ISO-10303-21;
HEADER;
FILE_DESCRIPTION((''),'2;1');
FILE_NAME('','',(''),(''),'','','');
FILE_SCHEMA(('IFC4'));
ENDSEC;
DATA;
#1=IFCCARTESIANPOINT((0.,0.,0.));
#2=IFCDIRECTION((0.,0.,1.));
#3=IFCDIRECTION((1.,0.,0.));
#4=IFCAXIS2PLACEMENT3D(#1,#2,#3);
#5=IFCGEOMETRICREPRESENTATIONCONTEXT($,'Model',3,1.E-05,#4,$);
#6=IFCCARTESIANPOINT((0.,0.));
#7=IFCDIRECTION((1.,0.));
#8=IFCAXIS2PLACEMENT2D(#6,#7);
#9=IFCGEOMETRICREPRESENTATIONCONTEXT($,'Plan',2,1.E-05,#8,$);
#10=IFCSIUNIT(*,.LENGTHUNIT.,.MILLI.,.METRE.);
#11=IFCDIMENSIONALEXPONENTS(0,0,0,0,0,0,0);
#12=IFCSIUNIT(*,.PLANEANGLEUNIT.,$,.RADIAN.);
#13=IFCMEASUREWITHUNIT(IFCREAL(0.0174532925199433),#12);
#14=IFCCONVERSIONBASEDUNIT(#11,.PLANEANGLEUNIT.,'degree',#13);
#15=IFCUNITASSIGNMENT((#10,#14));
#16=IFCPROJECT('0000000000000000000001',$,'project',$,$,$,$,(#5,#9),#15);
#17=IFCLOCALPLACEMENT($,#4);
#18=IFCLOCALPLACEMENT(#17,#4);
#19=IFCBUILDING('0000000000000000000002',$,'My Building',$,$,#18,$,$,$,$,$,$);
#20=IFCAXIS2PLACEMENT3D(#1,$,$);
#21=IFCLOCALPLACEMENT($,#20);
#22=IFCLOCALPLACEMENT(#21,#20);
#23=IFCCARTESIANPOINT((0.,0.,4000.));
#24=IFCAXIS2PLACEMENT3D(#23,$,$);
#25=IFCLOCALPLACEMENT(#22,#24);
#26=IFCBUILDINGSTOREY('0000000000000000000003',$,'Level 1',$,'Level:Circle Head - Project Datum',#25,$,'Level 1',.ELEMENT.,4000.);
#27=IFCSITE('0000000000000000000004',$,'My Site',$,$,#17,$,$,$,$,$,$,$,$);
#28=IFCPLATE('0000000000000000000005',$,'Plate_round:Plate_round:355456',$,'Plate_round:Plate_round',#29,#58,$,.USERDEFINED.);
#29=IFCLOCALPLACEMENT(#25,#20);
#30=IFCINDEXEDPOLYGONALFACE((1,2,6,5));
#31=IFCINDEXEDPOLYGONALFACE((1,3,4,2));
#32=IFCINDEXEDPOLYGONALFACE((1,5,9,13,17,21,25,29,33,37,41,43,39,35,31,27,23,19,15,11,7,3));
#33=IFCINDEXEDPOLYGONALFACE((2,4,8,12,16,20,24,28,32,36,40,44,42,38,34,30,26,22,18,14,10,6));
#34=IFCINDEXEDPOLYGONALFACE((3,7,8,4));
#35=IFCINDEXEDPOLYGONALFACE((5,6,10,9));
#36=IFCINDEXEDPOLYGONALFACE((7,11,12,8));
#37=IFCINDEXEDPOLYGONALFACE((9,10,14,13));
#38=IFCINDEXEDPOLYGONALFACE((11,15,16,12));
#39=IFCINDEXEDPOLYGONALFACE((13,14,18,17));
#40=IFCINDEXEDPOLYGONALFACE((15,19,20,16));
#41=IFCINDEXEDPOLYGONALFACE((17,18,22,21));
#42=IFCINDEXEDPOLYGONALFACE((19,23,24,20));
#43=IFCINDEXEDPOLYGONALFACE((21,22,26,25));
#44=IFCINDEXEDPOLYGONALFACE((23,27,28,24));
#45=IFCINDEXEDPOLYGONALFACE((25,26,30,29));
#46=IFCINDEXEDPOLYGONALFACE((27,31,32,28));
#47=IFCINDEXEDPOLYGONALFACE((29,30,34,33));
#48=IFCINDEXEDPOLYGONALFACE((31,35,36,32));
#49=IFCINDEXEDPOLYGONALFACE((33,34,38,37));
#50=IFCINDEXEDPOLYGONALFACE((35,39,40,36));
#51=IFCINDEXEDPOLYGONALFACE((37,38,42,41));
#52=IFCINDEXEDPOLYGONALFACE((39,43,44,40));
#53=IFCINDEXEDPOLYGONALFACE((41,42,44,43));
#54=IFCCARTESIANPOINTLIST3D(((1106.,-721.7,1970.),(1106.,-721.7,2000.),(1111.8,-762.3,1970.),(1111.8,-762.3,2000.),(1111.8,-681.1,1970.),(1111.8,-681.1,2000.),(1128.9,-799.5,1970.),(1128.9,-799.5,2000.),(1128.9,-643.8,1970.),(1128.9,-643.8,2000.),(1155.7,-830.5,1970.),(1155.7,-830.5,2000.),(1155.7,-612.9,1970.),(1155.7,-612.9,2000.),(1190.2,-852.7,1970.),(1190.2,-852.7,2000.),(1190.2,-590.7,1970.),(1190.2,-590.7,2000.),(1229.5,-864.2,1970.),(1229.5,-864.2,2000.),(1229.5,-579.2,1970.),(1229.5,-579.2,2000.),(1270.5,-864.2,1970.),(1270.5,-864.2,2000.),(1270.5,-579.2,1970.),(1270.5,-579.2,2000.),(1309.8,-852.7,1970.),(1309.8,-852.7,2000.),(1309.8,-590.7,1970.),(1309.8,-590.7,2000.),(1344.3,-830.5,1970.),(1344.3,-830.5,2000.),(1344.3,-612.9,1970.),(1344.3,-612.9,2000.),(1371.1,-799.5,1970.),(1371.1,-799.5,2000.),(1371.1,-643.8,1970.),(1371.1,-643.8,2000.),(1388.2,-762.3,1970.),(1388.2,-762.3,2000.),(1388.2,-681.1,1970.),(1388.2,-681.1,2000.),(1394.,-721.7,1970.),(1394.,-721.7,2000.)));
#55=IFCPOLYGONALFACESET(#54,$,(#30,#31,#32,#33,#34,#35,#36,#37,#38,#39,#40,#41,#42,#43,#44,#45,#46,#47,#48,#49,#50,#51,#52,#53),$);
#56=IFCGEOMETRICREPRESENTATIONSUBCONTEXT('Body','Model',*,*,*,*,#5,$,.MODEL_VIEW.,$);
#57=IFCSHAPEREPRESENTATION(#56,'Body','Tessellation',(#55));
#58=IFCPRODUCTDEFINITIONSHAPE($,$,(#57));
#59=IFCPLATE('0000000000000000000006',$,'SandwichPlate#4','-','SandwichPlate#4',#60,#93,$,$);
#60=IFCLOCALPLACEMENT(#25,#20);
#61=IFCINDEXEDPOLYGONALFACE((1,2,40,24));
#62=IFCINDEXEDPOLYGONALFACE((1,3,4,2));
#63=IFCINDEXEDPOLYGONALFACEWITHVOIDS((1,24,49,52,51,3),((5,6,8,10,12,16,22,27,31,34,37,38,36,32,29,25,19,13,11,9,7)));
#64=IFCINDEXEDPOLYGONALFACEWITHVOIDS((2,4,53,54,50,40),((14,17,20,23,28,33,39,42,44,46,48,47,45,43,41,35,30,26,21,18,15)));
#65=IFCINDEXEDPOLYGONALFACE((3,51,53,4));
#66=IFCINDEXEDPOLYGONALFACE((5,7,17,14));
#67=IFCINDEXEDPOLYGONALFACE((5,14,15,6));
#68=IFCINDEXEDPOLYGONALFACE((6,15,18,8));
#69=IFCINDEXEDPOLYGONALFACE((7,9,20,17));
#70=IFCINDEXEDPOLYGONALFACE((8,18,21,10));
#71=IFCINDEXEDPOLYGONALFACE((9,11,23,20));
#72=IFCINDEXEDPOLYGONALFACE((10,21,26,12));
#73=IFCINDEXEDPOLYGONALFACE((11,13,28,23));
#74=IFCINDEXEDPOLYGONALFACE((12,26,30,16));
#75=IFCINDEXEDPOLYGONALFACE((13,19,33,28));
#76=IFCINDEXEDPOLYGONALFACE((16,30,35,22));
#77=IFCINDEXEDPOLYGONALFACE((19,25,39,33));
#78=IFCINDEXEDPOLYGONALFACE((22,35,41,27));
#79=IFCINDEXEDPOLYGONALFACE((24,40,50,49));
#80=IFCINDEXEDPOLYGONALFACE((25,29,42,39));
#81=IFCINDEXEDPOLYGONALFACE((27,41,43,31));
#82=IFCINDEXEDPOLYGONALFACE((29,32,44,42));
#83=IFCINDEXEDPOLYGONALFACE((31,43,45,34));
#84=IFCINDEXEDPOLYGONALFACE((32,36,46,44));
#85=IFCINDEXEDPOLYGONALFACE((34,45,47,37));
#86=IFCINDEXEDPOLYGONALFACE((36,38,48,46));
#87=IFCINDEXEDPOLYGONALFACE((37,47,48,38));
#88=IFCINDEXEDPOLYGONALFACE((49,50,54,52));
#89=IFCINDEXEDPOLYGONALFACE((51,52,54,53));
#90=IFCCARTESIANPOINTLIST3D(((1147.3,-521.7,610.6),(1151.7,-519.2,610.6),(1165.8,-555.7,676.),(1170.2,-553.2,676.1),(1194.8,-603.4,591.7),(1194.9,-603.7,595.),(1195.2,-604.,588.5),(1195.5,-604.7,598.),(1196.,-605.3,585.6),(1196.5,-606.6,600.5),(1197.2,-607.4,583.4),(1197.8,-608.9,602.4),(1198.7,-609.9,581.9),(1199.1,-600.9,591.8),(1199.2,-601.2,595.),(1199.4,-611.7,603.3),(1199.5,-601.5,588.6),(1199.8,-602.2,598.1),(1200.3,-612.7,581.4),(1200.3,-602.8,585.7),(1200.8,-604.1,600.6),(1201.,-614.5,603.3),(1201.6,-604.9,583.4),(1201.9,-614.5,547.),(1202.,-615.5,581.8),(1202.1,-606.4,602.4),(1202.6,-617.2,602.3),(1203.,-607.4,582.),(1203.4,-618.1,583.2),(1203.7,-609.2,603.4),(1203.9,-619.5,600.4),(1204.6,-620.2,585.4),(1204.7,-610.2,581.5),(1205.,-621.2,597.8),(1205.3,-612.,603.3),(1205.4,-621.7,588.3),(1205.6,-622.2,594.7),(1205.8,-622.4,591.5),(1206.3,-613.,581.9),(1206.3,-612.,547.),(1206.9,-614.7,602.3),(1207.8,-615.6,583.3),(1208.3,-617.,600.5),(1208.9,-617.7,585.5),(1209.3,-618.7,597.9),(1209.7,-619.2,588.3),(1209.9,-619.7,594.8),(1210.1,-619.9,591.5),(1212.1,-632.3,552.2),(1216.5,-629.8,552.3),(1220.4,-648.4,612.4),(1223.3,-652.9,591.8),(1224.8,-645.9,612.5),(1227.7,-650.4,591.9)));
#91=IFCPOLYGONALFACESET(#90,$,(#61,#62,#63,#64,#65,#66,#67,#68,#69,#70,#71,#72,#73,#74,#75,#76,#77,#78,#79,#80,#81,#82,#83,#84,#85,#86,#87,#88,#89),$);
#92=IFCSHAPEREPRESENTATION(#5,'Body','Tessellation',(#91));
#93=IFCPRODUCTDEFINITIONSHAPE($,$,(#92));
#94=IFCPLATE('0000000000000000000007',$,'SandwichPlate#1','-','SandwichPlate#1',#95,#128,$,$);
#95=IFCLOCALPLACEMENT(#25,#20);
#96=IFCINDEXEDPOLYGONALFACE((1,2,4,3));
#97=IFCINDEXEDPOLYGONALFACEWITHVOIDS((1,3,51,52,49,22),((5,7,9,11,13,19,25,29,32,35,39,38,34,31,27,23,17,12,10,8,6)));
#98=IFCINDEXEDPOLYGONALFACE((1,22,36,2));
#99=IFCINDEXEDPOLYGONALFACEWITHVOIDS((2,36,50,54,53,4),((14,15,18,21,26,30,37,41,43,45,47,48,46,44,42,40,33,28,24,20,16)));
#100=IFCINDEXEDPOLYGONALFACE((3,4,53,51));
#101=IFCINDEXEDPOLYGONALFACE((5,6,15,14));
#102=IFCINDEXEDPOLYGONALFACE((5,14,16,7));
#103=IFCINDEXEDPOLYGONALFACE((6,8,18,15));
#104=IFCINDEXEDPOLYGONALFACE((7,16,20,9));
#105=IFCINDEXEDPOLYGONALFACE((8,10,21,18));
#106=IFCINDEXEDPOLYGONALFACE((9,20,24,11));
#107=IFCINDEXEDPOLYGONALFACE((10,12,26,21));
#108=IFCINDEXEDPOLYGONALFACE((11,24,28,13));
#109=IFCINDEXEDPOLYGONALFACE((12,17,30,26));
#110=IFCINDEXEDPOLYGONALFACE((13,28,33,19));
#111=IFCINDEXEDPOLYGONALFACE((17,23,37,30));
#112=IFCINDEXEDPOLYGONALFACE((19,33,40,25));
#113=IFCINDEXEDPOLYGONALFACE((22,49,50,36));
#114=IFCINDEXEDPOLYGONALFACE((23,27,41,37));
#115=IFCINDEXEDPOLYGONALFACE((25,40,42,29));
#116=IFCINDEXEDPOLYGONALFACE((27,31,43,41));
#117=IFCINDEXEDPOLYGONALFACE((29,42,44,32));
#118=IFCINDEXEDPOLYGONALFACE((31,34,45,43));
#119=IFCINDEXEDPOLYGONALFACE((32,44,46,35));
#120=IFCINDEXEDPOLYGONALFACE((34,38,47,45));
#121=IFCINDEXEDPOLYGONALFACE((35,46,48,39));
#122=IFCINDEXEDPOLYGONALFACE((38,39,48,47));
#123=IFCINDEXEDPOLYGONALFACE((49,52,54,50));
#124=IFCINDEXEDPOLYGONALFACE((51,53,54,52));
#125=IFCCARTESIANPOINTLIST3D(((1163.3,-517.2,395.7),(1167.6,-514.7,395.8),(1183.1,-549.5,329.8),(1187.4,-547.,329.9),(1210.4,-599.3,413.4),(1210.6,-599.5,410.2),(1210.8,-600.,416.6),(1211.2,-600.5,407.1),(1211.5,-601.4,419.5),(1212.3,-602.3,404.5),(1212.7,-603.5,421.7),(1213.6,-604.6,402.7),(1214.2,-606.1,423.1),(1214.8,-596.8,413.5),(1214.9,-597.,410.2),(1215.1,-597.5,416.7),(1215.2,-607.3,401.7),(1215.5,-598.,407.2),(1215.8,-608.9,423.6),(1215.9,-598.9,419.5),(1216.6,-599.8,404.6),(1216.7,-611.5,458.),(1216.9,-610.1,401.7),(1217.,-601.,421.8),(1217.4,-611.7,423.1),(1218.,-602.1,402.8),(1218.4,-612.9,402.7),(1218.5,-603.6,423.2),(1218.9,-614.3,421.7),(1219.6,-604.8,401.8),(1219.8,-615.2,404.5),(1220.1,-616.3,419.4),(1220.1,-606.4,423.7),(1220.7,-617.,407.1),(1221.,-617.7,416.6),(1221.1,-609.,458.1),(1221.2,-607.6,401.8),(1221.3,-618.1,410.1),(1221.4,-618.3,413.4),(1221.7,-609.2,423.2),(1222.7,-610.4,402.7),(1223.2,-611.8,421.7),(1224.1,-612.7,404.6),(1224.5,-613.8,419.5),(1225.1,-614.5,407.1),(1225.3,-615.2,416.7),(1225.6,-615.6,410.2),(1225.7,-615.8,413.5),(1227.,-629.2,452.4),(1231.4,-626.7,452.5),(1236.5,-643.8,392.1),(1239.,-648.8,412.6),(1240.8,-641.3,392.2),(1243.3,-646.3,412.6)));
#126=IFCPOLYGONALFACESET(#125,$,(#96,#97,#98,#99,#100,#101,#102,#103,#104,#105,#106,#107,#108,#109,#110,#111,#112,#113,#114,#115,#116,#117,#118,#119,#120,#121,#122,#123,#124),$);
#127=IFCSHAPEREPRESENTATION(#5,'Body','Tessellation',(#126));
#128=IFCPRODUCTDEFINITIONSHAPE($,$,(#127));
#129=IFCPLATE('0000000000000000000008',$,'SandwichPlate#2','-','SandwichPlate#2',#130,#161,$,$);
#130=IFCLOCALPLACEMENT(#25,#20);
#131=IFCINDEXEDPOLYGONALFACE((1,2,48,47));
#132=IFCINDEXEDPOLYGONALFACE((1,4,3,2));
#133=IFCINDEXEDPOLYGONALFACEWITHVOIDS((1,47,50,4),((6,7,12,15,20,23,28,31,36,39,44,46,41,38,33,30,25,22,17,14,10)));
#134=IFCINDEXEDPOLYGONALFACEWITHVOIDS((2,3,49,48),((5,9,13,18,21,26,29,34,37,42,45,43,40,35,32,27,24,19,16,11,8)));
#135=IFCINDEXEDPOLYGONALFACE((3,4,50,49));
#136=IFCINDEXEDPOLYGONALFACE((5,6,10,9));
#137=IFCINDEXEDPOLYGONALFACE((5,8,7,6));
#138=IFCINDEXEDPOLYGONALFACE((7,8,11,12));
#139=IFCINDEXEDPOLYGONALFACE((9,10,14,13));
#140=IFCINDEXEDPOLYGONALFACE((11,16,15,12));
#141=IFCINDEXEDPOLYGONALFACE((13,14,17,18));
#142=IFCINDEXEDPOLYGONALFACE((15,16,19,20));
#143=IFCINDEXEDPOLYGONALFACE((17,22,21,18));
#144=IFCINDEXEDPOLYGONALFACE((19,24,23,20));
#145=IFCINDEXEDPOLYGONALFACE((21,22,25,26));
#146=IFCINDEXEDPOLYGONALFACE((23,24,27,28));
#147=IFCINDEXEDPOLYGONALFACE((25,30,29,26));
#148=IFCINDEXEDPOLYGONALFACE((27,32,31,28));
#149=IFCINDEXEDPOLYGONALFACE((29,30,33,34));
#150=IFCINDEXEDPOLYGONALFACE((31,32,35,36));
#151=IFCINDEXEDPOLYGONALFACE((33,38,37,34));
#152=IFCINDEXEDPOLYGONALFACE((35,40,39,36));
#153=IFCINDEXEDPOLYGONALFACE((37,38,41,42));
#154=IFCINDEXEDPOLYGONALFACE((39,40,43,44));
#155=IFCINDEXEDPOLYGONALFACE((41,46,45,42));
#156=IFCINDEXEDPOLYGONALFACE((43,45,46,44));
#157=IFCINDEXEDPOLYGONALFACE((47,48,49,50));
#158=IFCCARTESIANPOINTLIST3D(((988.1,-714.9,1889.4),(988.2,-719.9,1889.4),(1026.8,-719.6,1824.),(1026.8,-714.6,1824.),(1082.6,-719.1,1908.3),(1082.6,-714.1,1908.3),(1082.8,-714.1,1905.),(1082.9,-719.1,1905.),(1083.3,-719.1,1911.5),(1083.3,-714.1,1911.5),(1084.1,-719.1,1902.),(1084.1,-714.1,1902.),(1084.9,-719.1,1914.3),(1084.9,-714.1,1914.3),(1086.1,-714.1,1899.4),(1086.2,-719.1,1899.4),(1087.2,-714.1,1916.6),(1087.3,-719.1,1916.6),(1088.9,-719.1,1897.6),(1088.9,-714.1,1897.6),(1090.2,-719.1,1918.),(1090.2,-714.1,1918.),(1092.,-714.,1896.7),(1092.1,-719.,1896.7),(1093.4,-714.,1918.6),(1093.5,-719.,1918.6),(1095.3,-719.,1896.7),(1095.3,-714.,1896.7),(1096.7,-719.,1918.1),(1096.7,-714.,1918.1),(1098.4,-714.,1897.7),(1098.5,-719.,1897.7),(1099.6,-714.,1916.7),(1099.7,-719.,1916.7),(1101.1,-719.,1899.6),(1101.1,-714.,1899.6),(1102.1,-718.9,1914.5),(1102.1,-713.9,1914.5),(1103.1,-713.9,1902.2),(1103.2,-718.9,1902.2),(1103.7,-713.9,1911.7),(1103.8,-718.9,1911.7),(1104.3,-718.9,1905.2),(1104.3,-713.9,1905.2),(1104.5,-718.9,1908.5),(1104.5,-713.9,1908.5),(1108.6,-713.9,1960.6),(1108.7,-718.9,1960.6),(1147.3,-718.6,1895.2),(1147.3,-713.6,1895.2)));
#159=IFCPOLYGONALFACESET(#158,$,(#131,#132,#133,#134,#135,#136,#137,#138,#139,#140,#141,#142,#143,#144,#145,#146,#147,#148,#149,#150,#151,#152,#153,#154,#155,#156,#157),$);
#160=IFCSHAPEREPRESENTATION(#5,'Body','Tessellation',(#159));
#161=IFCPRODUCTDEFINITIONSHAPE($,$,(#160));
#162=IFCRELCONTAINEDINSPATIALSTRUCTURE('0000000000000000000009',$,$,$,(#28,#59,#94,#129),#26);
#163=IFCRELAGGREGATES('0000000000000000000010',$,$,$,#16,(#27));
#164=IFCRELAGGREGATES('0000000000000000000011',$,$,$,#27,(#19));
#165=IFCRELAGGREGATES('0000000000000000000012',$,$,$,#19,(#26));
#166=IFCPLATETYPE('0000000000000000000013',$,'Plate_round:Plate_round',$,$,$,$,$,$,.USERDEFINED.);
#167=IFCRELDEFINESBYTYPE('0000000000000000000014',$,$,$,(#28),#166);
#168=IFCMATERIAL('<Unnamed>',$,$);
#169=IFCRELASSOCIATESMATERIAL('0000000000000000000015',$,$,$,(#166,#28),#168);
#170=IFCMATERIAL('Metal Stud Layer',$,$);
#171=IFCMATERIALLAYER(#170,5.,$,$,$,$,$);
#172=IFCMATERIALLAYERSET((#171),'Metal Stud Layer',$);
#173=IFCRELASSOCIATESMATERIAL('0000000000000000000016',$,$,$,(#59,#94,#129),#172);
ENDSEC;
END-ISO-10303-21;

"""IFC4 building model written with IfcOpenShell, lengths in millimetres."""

from ifc_helpers import new_model, entity, si_unit, converted_unit, frame, origin, origin_with_axes, origin_2d_with_axis, place, context, subcontext, project, spatial, polyline, arc, indexed_curve, circle, outline, extrude, source, transform, mapped, material, layer, layer_set, type_object, type_shapes, element, save


model = new_model("IFC4")

# Units and contexts
model_context = context("Model", 3, precision=1e-05, world=origin_with_axes())
plan_context = context("Plan", 2, precision=1e-05, world=origin_2d_with_axis())
body_context = subcontext(model_context, "Body", "Model", "MODEL_VIEW")
ifc_project = project(units=[si_unit("LENGTHUNIT", "METRE", prefix="MILLI"), converted_unit("PLANEANGLEUNIT", "degree", entity("IfcReal", 0.0174532925199433), si_unit("PLANEANGLEUNIT", "RADIAN"), dimensions=[0, 0, 0, 0, 0, 0, 0])], contexts=[model_context, plan_context])

# Site, building, storey
site_placement = place(None, origin_with_axes())
site = spatial("IfcSite", under=ifc_project, at=site_placement, Name="My Site")
building_placement = place(site_placement, origin_with_axes())
building = spatial("IfcBuilding", under=site, at=building_placement, Name="My Building")
placement_1 = place(None, origin())
placement_2 = place(placement_1, origin())
storey_placement = place(placement_2, frame((0.0, 0.0, 4000.0)))
storey = spatial("IfcBuildingStorey", under=building, at=storey_placement, Name="Level 1", ObjectType="Level:Circle Head - Project Datum", LongName="Level 1", CompositionType="ELEMENT", Elevation=4000.0)

# Plate
ifc_material_1 = material(Name="<Unnamed>")
plate_type = type_object("IfcPlateType", Name="Plate_round:Plate_round", PredefinedType="USERDEFINED", material=ifc_material_1)
shared_shape = source(origin(), body_context, "Body", "SweptSolid", [
    extrude(outline(indexed_curve([(-144.0, 0.0), (0.0, -144.0), (144.0, 0.0), (0.0, 144.0)], segments=[arc(1, 2, 3), arc(3, 4, 1)], self_intersect=False)), origin(), (0.0, 0.0, 1.0), 30.0),
])
type_shapes(plate_type, [shared_shape])
plate_1_placement = place(storey_placement, frame((1250.0, -721.7, 1970.0)))
element("IfcPlate", 1, at=plate_1_placement, inside=storey, type_object=plate_type, material=ifc_material_1, Name="Plate_round:Plate_round:355456", ObjectType="Plate_round:Plate_round", PredefinedType="USERDEFINED", context=body_context, shape_type="MappedRepresentation", body=[
    mapped(shared_shape, transform((0.0, 0.0, 0.0), scale=1.0)),
])

# Plates, openings
ifc_material_2 = material(Name="Metal Stud Layer")
ifc_layer_1 = layer(ifc_material_2, 5.0)
ifc_layer_set_1 = layer_set([ifc_layer_1], Name="Metal Stud Layer")
plate_2_placement = place(storey_placement, frame((1212.8, -623.1, 539.4), z_axis=(-0.865935, -0.499948, -0.014432), x_axis=(0.243701, -0.44695, 0.860724)))
plate_2 = element("IfcPlate", 2, at=plate_2_placement, inside=storey, material=ifc_layer_set_1, Name="SandwichPlate#4", Description="-", ObjectType="SandwichPlate#4", context=model_context, shape_type="SweptSolid", body=[
    extrude(outline(polyline([(0.0, 0.0), (76.0, 0.0), (76.0, 140.0), (0.0, 140.0), (0.0, 0.0)])), origin_with_axes(), (0.0, 0.0, 1.0), 5.0),
])
opening_1_placement = place(plate_2_placement, frame((0.0, 0.0, 0.0), z_axis=(0.0, 0.0, 1.0), x_axis=(1.0, 0.0, 0.0)))
element("IfcOpeningElement", 3, at=opening_1_placement, cuts=plate_2, ObjectType="Opening", context=model_context, shape_type="SweptSolid", body=[
    extrude(outline(polyline([(0.0, 0.0), (15.0, 0.0), (0.0, 15.0), (0.0, 0.0)])), origin(), (0.0, 0.0, 1.0), 5.0),
])
opening_2_placement = place(plate_2_placement, frame((0.0, 0.0, 0.0), z_axis=(0.0, 0.0, 1.0), x_axis=(1.0, 0.0, 0.0)))
element("IfcOpeningElement", 4, at=opening_2_placement, cuts=plate_2, ObjectType="Opening", context=model_context, shape_type="SweptSolid", body=[
    extrude(outline(polyline([(76.0, 0.0), (76.0, 15.0), (61.0, 0.0), (76.0, 0.0)])), origin(), (0.0, 0.0, 1.0), 5.0),
])
opening_3_placement = place(plate_2_placement, frame((38.0, 40.0, -0.5), z_axis=(0.0, 0.0, 1.0), x_axis=(0.0, 1.0, 0.0)))
element("IfcOpeningElement", 5, at=opening_3_placement, cuts=plate_2, ObjectType="Opening", context=model_context, shape_type="SweptSolid", body=[
    extrude(circle(Radius=11.0, at=origin_2d_with_axis()), origin(), (0.0, 0.0, 1.0), 6.0),
])
plate_3_placement = place(storey_placement, frame((1247.2, -652.7, 399.6), z_axis=(-0.865935, -0.499948, -0.014432), x_axis=(-0.259821, 0.424992, 0.867107)))
plate_3 = element("IfcPlate", 6, at=plate_3_placement, inside=storey, material=ifc_layer_set_1, Name="SandwichPlate#1", Description="-", ObjectType="SandwichPlate#1", context=model_context, shape_type="SweptSolid", body=[
    extrude(outline(polyline([(0.0, 0.0), (76.0, 0.0), (76.0, 140.0), (0.0, 140.0), (0.0, 0.0)])), origin_with_axes(), (0.0, 0.0, 1.0), 5.0),
])
opening_4_placement = place(plate_3_placement, frame((0.0, 0.0, 0.0), z_axis=(0.0, 0.0, 1.0), x_axis=(1.0, 0.0, 0.0)))
element("IfcOpeningElement", 7, at=opening_4_placement, cuts=plate_3, ObjectType="Opening", context=model_context, shape_type="SweptSolid", body=[
    extrude(outline(polyline([(0.0, 0.0), (15.0, 0.0), (0.0, 15.0), (0.0, 0.0)])), origin(), (0.0, 0.0, 1.0), 5.0),
])
opening_5_placement = place(plate_3_placement, frame((0.0, 0.0, 0.0), z_axis=(0.0, 0.0, 1.0), x_axis=(1.0, 0.0, 0.0)))
element("IfcOpeningElement", 8, at=opening_5_placement, cuts=plate_3, ObjectType="Opening", context=model_context, shape_type="SweptSolid", body=[
    extrude(outline(polyline([(76.0, 0.0), (76.0, 15.0), (61.0, 0.0), (76.0, 0.0)])), origin(), (0.0, 0.0, 1.0), 5.0),
])
opening_6_placement = place(plate_3_placement, frame((38.0, 40.0, -0.5), z_axis=(0.0, 0.0, 1.0), x_axis=(0.0, 1.0, 0.0)))
element("IfcOpeningElement", 9, at=opening_6_placement, cuts=plate_3, ObjectType="Opening", context=model_context, shape_type="SweptSolid", body=[
    extrude(circle(Radius=11.0, at=origin_2d_with_axis()), origin(), (0.0, 0.0, 1.0), 6.0),
])

# Plate, opening
plate_4_placement = place(storey_placement, frame((1108.7, -718.9, 1960.6), z_axis=(-0.008532, 0.999964, 0.0), x_axis=(0.50884, 0.004342, -0.86085)))
plate_4 = element("IfcPlate", 10, at=plate_4_placement, inside=storey, material=ifc_layer_set_1, Name="SandwichPlate#2", Description="-", ObjectType="SandwichPlate#2", context=model_context, shape_type="SweptSolid", body=[
    extrude(outline(polyline([(0.0, 0.0), (76.0, 0.0), (76.0, 140.0), (0.0, 140.0), (0.0, 0.0)])), origin_with_axes(), (0.0, 0.0, 1.0), 5.0),
])
opening_7_placement = place(plate_4_placement, frame((38.0, 40.0, -0.5), z_axis=(0.0, 0.0, 1.0), x_axis=(0.0, 1.0, 0.0)))
element("IfcOpeningElement", 11, at=opening_7_placement, cuts=plate_4, ObjectType="Opening", context=model_context, shape_type="SweptSolid", body=[
    extrude(circle(Radius=11.0, at=origin_2d_with_axis()), origin(), (0.0, 0.0, 1.0), 6.0),
])

save(model, "model.ifc")
